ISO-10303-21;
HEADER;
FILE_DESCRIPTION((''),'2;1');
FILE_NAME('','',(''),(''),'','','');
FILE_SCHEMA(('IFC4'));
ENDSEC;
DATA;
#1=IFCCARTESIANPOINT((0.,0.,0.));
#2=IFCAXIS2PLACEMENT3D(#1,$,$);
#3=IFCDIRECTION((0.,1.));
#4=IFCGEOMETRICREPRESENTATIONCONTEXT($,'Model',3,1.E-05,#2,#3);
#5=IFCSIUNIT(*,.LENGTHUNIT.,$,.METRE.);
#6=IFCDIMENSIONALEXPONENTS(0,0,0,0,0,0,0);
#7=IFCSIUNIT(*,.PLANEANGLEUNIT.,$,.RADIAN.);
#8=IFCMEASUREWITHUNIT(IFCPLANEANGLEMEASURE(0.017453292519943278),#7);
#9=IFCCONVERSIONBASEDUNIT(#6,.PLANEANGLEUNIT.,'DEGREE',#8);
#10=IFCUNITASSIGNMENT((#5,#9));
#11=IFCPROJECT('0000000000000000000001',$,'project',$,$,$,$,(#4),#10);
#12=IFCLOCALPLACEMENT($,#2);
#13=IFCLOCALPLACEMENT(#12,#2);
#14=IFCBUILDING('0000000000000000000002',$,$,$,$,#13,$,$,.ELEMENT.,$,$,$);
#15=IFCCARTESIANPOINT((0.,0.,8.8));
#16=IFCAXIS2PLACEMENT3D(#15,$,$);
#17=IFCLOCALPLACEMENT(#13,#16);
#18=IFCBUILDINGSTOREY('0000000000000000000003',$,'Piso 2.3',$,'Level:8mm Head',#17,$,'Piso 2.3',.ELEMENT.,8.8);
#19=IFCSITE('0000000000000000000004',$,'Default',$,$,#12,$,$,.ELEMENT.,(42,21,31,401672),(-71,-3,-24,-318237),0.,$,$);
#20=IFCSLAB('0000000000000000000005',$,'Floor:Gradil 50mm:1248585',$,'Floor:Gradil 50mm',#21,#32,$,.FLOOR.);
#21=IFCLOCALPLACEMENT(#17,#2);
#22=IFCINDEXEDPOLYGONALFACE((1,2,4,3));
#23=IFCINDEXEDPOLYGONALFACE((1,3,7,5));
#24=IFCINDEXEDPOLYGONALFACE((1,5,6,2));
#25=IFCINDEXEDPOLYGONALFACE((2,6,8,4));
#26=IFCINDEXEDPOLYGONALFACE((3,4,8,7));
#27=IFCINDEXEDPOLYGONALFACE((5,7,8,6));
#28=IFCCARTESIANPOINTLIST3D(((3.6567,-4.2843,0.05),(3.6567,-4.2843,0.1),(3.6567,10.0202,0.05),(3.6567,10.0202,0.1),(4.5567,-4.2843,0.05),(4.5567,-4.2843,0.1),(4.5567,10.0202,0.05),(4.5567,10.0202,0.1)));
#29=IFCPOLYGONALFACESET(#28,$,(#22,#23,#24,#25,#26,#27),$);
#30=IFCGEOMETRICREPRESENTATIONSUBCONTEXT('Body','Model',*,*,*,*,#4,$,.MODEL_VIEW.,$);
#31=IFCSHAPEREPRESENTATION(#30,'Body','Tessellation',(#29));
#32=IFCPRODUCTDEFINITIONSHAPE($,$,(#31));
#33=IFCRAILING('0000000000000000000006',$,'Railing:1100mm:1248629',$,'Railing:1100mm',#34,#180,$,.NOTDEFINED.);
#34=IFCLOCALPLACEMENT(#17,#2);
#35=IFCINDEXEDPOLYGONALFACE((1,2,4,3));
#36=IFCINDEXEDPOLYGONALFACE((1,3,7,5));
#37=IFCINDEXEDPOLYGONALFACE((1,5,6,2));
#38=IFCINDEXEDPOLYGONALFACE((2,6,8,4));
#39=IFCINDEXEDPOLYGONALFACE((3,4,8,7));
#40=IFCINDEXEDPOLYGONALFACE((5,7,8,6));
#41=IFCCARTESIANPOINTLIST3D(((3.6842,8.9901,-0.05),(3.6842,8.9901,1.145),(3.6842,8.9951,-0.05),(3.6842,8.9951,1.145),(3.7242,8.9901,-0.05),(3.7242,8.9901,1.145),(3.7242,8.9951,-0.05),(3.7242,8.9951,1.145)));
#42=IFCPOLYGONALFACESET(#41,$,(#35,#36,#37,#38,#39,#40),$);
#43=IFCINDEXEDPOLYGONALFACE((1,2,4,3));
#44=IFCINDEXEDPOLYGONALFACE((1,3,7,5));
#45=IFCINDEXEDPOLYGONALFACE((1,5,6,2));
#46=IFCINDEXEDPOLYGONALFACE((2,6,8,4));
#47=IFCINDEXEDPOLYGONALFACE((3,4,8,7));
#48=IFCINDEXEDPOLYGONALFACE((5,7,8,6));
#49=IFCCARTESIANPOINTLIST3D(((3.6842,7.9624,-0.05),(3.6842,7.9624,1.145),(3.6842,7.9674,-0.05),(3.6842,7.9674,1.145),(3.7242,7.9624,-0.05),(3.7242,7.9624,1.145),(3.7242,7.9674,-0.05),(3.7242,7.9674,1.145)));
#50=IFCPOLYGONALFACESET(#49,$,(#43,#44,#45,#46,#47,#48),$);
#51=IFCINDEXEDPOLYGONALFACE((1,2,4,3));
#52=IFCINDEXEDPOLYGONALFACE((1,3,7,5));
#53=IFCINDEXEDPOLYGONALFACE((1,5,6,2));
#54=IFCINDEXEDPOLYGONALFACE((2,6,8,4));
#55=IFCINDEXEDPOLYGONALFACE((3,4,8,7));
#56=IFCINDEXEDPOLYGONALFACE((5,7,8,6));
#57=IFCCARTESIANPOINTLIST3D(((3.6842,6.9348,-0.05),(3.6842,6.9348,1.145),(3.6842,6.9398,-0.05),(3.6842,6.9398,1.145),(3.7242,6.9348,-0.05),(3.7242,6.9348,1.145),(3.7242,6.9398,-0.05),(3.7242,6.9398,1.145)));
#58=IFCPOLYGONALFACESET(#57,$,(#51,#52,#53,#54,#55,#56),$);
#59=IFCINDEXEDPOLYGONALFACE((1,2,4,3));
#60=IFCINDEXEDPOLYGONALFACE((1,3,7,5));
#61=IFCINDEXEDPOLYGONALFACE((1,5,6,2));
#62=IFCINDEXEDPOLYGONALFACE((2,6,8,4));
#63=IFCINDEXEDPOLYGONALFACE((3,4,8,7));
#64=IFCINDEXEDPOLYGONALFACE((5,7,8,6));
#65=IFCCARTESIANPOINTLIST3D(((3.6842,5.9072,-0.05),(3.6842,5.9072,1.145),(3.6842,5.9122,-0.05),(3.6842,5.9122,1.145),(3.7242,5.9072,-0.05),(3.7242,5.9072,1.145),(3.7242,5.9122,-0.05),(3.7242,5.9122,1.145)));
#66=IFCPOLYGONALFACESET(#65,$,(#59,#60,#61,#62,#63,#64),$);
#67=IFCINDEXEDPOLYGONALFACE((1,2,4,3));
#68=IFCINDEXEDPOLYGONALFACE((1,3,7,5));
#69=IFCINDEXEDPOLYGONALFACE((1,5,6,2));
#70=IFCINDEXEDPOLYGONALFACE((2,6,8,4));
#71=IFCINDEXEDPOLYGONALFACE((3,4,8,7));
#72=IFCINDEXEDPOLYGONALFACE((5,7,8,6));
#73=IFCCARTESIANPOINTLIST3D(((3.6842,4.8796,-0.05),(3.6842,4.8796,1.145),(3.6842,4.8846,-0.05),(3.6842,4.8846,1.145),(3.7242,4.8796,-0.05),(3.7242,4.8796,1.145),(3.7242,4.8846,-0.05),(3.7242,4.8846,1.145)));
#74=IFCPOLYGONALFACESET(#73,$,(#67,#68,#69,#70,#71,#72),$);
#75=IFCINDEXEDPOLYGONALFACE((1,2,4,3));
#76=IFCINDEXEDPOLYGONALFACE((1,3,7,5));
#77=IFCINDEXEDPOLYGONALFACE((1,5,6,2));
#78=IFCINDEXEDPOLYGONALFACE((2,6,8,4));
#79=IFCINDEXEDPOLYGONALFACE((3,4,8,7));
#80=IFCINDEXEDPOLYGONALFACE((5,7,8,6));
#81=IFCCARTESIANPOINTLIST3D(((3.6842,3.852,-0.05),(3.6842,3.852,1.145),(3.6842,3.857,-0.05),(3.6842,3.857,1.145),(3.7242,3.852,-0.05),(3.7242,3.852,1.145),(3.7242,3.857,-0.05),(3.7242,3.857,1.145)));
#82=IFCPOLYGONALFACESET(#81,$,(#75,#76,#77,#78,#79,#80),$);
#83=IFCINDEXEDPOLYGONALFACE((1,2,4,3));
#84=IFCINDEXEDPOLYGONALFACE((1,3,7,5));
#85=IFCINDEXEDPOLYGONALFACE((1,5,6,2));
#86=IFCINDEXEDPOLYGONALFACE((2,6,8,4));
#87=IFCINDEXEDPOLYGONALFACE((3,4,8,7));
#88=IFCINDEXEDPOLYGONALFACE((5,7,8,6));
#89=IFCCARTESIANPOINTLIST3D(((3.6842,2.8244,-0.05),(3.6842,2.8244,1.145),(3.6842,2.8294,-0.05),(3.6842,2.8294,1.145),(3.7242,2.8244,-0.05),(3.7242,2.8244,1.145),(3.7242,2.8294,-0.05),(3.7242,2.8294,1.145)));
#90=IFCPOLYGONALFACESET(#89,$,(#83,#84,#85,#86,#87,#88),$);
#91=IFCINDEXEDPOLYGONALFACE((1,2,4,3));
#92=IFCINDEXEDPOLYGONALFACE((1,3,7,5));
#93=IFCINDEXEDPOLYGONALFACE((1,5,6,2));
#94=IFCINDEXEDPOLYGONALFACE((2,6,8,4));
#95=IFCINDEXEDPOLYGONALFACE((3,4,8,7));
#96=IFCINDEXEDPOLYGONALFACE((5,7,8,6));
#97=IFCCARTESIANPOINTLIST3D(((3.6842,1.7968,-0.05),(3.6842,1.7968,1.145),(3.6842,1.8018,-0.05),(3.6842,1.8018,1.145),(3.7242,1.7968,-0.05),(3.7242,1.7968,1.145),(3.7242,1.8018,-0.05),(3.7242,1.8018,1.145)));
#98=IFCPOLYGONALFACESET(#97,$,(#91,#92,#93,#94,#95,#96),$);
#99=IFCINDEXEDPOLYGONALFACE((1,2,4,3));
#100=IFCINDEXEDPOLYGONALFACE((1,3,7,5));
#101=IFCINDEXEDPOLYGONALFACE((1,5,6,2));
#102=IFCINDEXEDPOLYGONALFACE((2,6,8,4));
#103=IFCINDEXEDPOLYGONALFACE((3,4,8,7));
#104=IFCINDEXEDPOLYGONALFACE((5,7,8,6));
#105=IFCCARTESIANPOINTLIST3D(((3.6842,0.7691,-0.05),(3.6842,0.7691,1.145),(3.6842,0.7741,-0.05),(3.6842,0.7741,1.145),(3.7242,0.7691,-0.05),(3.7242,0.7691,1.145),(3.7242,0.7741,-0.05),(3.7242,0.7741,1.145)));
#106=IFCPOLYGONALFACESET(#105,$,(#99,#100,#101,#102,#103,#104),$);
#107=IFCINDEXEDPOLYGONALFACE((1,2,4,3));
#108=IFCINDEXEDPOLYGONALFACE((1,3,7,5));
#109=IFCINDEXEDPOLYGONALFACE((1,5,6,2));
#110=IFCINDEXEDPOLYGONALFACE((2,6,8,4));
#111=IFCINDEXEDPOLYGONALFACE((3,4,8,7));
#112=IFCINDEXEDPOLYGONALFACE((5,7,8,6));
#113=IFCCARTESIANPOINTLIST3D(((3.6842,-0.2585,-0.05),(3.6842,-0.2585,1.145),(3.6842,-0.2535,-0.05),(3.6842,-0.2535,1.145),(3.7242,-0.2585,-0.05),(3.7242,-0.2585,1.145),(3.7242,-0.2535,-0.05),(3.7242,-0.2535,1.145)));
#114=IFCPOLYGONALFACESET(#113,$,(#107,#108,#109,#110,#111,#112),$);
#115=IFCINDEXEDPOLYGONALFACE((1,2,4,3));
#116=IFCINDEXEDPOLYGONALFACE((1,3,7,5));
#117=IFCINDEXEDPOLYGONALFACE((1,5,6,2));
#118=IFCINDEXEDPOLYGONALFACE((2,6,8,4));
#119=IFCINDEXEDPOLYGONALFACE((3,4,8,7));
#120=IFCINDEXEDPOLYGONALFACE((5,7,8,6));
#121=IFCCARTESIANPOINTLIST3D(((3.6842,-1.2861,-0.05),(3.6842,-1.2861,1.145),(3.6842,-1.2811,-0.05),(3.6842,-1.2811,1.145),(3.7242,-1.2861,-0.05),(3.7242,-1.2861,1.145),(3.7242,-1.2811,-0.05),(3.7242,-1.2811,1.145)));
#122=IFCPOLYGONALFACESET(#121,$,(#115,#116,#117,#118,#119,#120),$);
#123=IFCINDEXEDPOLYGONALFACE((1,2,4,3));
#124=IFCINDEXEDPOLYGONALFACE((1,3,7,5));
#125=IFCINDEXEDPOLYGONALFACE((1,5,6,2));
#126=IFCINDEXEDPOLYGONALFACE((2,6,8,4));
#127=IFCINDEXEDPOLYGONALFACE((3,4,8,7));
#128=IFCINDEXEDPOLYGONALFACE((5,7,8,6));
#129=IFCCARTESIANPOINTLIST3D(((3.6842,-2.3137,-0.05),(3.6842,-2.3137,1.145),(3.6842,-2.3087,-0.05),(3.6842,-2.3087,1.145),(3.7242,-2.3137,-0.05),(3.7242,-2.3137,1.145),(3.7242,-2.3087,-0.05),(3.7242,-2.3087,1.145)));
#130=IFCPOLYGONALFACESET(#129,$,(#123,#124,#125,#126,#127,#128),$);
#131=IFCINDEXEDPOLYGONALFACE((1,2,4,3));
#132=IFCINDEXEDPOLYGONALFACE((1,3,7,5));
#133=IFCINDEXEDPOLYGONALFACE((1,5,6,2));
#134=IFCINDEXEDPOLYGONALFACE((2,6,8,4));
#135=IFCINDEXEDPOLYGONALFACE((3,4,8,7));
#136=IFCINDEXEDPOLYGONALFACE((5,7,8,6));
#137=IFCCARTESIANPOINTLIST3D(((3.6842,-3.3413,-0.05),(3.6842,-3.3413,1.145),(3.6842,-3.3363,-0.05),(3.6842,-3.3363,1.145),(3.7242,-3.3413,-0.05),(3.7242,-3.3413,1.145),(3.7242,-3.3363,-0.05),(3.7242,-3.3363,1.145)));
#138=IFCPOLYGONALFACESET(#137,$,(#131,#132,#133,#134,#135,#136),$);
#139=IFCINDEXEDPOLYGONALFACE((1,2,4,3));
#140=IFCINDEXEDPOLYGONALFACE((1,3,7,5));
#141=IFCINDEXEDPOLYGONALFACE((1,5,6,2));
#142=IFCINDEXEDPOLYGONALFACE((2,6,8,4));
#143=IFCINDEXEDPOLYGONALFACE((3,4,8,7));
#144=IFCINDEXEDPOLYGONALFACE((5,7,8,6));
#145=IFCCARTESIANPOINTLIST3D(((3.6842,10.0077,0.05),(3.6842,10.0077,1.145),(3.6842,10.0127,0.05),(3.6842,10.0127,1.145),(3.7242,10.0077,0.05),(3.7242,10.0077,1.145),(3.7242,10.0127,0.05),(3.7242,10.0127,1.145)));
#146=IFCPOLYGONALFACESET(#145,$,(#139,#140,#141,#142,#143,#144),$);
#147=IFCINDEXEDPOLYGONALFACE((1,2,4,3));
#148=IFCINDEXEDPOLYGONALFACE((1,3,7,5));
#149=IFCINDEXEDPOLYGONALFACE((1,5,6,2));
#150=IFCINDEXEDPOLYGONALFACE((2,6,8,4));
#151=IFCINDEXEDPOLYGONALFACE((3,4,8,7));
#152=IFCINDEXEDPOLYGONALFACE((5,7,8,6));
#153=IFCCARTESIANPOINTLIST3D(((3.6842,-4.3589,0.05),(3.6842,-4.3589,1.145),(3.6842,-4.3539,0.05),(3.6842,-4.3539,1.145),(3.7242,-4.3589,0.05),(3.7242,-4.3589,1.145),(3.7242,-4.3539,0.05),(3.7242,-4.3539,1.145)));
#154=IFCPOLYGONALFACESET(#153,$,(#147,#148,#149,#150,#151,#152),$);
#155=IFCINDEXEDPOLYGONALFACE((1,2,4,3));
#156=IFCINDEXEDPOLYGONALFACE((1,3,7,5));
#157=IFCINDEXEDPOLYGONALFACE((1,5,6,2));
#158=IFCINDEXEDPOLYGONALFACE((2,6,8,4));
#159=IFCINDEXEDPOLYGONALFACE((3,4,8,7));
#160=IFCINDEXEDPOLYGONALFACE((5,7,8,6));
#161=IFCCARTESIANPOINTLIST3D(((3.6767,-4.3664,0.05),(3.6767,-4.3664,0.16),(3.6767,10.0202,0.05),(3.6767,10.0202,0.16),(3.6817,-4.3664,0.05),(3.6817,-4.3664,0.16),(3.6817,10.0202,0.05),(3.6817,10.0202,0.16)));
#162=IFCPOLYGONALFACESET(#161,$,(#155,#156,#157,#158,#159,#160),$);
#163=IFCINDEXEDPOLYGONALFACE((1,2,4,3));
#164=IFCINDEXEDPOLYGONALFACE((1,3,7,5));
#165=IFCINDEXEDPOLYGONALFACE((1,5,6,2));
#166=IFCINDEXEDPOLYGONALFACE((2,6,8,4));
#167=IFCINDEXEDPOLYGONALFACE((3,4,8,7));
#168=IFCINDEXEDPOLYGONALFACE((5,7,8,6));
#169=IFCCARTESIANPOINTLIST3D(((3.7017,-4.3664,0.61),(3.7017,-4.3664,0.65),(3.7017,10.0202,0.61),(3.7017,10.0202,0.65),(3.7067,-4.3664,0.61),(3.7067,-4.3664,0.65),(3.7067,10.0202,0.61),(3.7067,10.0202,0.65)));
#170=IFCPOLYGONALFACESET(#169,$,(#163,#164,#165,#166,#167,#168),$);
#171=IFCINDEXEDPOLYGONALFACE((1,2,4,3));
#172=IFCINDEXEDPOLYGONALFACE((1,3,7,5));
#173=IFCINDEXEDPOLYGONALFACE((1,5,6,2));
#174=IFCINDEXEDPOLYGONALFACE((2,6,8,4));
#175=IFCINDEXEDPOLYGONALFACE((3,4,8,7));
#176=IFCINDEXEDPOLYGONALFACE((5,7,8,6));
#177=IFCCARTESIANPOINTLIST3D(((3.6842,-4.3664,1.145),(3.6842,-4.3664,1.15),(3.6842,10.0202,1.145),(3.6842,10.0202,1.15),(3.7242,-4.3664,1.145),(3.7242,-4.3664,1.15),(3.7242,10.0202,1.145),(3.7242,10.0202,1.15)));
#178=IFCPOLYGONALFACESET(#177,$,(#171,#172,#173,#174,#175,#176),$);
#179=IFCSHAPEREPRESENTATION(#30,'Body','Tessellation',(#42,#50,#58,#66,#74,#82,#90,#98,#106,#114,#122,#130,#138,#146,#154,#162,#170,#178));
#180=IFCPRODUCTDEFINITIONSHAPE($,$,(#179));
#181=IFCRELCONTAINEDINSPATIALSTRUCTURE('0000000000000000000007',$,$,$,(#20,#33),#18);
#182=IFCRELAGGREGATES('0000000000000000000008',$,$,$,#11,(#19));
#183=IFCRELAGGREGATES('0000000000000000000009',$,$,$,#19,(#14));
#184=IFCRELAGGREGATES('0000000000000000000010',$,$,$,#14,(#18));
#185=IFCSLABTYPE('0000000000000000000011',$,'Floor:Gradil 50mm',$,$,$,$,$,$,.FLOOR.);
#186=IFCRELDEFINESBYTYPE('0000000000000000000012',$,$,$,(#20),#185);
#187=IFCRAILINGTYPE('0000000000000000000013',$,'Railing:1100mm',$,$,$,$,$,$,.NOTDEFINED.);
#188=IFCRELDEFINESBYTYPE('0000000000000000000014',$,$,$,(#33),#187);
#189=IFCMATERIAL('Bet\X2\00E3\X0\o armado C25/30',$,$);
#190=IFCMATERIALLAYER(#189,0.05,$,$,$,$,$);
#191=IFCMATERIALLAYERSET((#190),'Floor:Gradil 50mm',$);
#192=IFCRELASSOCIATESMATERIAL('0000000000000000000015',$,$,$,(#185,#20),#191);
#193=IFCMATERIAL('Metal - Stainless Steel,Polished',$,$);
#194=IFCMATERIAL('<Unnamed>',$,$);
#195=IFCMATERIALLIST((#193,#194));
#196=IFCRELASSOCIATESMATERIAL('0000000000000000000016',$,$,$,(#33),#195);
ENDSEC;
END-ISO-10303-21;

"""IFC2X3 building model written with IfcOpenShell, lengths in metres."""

from ifc_helpers import new_model, entity, si_unit, converted_unit, direction, frame, frame_2d, origin, place, context, subcontext, project, spatial, rectangle, extrude, material, material_list, layer, layer_set, layer_usage, type_object, element, save


model = new_model("IFC2X3")

# Units and contexts
model_context = context("Model", 3, precision=1e-05, world=origin(), true_north=direction((0.0, 1.0)))
body_context = subcontext(model_context, "Body", "Model", "MODEL_VIEW")
ifc_project = project(units=[si_unit("LENGTHUNIT", "METRE"), converted_unit("PLANEANGLEUNIT", "DEGREE", entity("IfcPlaneAngleMeasure", 0.017453292519943278), si_unit("PLANEANGLEUNIT", "RADIAN"), dimensions=[0, 0, 0, 0, 0, 0, 0])], contexts=[model_context])

# Site, building, storey
site_placement = place(None, origin())
site = spatial("IfcSite", under=ifc_project, at=site_placement, Name="Default", CompositionType="ELEMENT", RefLatitude=(42, 21, 31, 401672), RefLongitude=(-71, -3, -24, -318237), RefElevation=0.0)
building_placement = place(site_placement, origin())
building = spatial("IfcBuilding", under=site, at=building_placement, CompositionType="ELEMENT")
storey_placement = place(building_placement, frame((0.0, 0.0, 8.8)))
storey = spatial("IfcBuildingStorey", under=building, at=storey_placement, Name="Piso 2.3", ObjectType="Level:8mm Head", LongName="Piso 2.3", CompositionType="ELEMENT", Elevation=8.8)

# Slab
ifc_material_1 = material(Name="Betão armado C25/30")
ifc_layer = layer(ifc_material_1, 0.05)
ifc_layer_set = layer_set([ifc_layer], Name="Floor:Gradil 50mm")
ifc_layer_usage = layer_usage(ifc_layer_set, "AXIS3", "POSITIVE", 0.0)
slab_type = type_object("IfcSlabType", Name="Floor:Gradil 50mm", PredefinedType="FLOOR", material=ifc_layer_set)
slab_placement = place(storey_placement, origin())
element("IfcSlab", 1, at=slab_placement, inside=storey, type_object=slab_type, material=ifc_layer_usage, Name="Floor:Gradil 50mm:1248585", ObjectType="Floor:Gradil 50mm", PredefinedType="FLOOR", context=body_context, shape_type="SweptSolid", body=[
    extrude(rectangle(XDim=14.3044, YDim=0.9, at=frame_2d((0.0, 0.0), x_axis=(1.0, 0.0))), frame((4.1067, 2.8679, 0.1), z_axis=(0.0, 0.0, -1.0), x_axis=(0.0, 1.0, 0.0)), (0.0, 0.0, 1.0), 0.05),
])

# Railing
ifc_material_2 = material(Name="Metal - Stainless Steel,Polished")
ifc_material_3 = material(Name="<Unnamed>")
ifc_material_list = material_list([ifc_material_2, ifc_material_3])
railing_type = type_object("IfcRailingType", Name="Railing:1100mm", PredefinedType="NOTDEFINED")
railing_placement = place(storey_placement, frame((3.6767, -4.3664, -0.05)))
element("IfcRailing", 2, at=railing_placement, inside=storey, type_object=railing_type, material=ifc_material_list, Name="Railing:1100mm:1248629", ObjectType="Railing:1100mm", PredefinedType="NOTDEFINED", context=body_context, shape_type="SweptSolid", body=[
    extrude(rectangle(XDim=0.04, YDim=0.005, at=frame_2d((0.0, 0.0), x_axis=(1.0, 0.0))), frame((0.0275, 13.359, 0.0)), (0.0, 0.0, 1.0), 1.195),
    extrude(rectangle(XDim=0.04, YDim=0.005, at=frame_2d((0.0, 0.0), x_axis=(1.0, 0.0))), frame((0.0275, 12.3314, 0.0)), (0.0, 0.0, 1.0), 1.195),
    extrude(rectangle(XDim=0.04, YDim=0.005, at=frame_2d((0.0, 0.0), x_axis=(1.0, 0.0))), frame((0.0275, 11.3038, 0.0)), (0.0, 0.0, 1.0), 1.195),
    extrude(rectangle(XDim=0.04, YDim=0.005, at=frame_2d((0.0, 0.0), x_axis=(1.0, 0.0))), frame((0.0275, 10.2761, 0.0)), (0.0, 0.0, 1.0), 1.195),
    extrude(rectangle(XDim=0.04, YDim=0.005, at=frame_2d((0.0, 0.0), x_axis=(1.0, 0.0))), frame((0.0275, 9.2485, 0.0)), (0.0, 0.0, 1.0), 1.195),
    extrude(rectangle(XDim=0.04, YDim=0.005, at=frame_2d((0.0, 0.0), x_axis=(1.0, 0.0))), frame((0.0275, 8.2209, 0.0)), (0.0, 0.0, 1.0), 1.195),
    extrude(rectangle(XDim=0.04, YDim=0.005, at=frame_2d((0.0, 0.0), x_axis=(1.0, 0.0))), frame((0.0275, 7.1933, 0.0)), (0.0, 0.0, 1.0), 1.195),
    extrude(rectangle(XDim=0.04, YDim=0.005, at=frame_2d((0.0, 0.0), x_axis=(1.0, 0.0))), frame((0.0275, 6.1657, 0.0)), (0.0, 0.0, 1.0), 1.195),
    extrude(rectangle(XDim=0.04, YDim=0.005, at=frame_2d((0.0, 0.0), x_axis=(1.0, 0.0))), frame((0.0275, 5.1381, 0.0)), (0.0, 0.0, 1.0), 1.195),
    extrude(rectangle(XDim=0.04, YDim=0.005, at=frame_2d((0.0, 0.0), x_axis=(1.0, 0.0))), frame((0.0275, 4.1105, 0.0)), (0.0, 0.0, 1.0), 1.195),
    extrude(rectangle(XDim=0.04, YDim=0.005, at=frame_2d((0.0, 0.0), x_axis=(1.0, 0.0))), frame((0.0275, 3.0828, 0.0)), (0.0, 0.0, 1.0), 1.195),
    extrude(rectangle(XDim=0.04, YDim=0.005, at=frame_2d((0.0, 0.0), x_axis=(1.0, 0.0))), frame((0.0275, 2.0552, 0.0)), (0.0, 0.0, 1.0), 1.195),
    extrude(rectangle(XDim=0.04, YDim=0.005, at=frame_2d((0.0, 0.0), x_axis=(1.0, 0.0))), frame((0.0275, 1.0276, 0.0)), (0.0, 0.0, 1.0), 1.195),
    extrude(rectangle(XDim=0.04, YDim=0.005, at=frame_2d((0.0, 0.0), x_axis=(1.0, 0.0))), frame((0.0275, 14.3766, 0.1)), (0.0, 0.0, 1.0), 1.095),
    extrude(rectangle(XDim=0.04, YDim=0.005, at=frame_2d((0.0, 0.0), x_axis=(1.0, 0.0))), frame((0.0275, 0.01, 0.1)), (0.0, 0.0, 1.0), 1.095),
    extrude(rectangle(XDim=14.3866, YDim=0.005, at=frame_2d((0.0, 0.0), x_axis=(1.0, 0.0))), frame((0.0025, 7.1933, 0.1), z_axis=(0.0, 0.0, 1.0), x_axis=(0.0, 1.0, 0.0)), (0.0, 0.0, 1.0), 0.11),
    extrude(rectangle(XDim=14.3866, YDim=0.005, at=frame_2d((0.0, 0.0), x_axis=(1.0, 0.0))), frame((0.0275, 7.1933, 0.66), z_axis=(0.0, 0.0, 1.0), x_axis=(0.0, 1.0, 0.0)), (0.0, 0.0, 1.0), 0.04),
    extrude(rectangle(XDim=14.3866, YDim=0.04, at=frame_2d((0.0, 0.0), x_axis=(1.0, 0.0))), frame((0.0275, 7.1933, 1.195), z_axis=(0.0, 0.0, 1.0), x_axis=(0.0, 1.0, 0.0)), (0.0, 0.0, 1.0), 0.005),
])

save(model, "model.ifc")
